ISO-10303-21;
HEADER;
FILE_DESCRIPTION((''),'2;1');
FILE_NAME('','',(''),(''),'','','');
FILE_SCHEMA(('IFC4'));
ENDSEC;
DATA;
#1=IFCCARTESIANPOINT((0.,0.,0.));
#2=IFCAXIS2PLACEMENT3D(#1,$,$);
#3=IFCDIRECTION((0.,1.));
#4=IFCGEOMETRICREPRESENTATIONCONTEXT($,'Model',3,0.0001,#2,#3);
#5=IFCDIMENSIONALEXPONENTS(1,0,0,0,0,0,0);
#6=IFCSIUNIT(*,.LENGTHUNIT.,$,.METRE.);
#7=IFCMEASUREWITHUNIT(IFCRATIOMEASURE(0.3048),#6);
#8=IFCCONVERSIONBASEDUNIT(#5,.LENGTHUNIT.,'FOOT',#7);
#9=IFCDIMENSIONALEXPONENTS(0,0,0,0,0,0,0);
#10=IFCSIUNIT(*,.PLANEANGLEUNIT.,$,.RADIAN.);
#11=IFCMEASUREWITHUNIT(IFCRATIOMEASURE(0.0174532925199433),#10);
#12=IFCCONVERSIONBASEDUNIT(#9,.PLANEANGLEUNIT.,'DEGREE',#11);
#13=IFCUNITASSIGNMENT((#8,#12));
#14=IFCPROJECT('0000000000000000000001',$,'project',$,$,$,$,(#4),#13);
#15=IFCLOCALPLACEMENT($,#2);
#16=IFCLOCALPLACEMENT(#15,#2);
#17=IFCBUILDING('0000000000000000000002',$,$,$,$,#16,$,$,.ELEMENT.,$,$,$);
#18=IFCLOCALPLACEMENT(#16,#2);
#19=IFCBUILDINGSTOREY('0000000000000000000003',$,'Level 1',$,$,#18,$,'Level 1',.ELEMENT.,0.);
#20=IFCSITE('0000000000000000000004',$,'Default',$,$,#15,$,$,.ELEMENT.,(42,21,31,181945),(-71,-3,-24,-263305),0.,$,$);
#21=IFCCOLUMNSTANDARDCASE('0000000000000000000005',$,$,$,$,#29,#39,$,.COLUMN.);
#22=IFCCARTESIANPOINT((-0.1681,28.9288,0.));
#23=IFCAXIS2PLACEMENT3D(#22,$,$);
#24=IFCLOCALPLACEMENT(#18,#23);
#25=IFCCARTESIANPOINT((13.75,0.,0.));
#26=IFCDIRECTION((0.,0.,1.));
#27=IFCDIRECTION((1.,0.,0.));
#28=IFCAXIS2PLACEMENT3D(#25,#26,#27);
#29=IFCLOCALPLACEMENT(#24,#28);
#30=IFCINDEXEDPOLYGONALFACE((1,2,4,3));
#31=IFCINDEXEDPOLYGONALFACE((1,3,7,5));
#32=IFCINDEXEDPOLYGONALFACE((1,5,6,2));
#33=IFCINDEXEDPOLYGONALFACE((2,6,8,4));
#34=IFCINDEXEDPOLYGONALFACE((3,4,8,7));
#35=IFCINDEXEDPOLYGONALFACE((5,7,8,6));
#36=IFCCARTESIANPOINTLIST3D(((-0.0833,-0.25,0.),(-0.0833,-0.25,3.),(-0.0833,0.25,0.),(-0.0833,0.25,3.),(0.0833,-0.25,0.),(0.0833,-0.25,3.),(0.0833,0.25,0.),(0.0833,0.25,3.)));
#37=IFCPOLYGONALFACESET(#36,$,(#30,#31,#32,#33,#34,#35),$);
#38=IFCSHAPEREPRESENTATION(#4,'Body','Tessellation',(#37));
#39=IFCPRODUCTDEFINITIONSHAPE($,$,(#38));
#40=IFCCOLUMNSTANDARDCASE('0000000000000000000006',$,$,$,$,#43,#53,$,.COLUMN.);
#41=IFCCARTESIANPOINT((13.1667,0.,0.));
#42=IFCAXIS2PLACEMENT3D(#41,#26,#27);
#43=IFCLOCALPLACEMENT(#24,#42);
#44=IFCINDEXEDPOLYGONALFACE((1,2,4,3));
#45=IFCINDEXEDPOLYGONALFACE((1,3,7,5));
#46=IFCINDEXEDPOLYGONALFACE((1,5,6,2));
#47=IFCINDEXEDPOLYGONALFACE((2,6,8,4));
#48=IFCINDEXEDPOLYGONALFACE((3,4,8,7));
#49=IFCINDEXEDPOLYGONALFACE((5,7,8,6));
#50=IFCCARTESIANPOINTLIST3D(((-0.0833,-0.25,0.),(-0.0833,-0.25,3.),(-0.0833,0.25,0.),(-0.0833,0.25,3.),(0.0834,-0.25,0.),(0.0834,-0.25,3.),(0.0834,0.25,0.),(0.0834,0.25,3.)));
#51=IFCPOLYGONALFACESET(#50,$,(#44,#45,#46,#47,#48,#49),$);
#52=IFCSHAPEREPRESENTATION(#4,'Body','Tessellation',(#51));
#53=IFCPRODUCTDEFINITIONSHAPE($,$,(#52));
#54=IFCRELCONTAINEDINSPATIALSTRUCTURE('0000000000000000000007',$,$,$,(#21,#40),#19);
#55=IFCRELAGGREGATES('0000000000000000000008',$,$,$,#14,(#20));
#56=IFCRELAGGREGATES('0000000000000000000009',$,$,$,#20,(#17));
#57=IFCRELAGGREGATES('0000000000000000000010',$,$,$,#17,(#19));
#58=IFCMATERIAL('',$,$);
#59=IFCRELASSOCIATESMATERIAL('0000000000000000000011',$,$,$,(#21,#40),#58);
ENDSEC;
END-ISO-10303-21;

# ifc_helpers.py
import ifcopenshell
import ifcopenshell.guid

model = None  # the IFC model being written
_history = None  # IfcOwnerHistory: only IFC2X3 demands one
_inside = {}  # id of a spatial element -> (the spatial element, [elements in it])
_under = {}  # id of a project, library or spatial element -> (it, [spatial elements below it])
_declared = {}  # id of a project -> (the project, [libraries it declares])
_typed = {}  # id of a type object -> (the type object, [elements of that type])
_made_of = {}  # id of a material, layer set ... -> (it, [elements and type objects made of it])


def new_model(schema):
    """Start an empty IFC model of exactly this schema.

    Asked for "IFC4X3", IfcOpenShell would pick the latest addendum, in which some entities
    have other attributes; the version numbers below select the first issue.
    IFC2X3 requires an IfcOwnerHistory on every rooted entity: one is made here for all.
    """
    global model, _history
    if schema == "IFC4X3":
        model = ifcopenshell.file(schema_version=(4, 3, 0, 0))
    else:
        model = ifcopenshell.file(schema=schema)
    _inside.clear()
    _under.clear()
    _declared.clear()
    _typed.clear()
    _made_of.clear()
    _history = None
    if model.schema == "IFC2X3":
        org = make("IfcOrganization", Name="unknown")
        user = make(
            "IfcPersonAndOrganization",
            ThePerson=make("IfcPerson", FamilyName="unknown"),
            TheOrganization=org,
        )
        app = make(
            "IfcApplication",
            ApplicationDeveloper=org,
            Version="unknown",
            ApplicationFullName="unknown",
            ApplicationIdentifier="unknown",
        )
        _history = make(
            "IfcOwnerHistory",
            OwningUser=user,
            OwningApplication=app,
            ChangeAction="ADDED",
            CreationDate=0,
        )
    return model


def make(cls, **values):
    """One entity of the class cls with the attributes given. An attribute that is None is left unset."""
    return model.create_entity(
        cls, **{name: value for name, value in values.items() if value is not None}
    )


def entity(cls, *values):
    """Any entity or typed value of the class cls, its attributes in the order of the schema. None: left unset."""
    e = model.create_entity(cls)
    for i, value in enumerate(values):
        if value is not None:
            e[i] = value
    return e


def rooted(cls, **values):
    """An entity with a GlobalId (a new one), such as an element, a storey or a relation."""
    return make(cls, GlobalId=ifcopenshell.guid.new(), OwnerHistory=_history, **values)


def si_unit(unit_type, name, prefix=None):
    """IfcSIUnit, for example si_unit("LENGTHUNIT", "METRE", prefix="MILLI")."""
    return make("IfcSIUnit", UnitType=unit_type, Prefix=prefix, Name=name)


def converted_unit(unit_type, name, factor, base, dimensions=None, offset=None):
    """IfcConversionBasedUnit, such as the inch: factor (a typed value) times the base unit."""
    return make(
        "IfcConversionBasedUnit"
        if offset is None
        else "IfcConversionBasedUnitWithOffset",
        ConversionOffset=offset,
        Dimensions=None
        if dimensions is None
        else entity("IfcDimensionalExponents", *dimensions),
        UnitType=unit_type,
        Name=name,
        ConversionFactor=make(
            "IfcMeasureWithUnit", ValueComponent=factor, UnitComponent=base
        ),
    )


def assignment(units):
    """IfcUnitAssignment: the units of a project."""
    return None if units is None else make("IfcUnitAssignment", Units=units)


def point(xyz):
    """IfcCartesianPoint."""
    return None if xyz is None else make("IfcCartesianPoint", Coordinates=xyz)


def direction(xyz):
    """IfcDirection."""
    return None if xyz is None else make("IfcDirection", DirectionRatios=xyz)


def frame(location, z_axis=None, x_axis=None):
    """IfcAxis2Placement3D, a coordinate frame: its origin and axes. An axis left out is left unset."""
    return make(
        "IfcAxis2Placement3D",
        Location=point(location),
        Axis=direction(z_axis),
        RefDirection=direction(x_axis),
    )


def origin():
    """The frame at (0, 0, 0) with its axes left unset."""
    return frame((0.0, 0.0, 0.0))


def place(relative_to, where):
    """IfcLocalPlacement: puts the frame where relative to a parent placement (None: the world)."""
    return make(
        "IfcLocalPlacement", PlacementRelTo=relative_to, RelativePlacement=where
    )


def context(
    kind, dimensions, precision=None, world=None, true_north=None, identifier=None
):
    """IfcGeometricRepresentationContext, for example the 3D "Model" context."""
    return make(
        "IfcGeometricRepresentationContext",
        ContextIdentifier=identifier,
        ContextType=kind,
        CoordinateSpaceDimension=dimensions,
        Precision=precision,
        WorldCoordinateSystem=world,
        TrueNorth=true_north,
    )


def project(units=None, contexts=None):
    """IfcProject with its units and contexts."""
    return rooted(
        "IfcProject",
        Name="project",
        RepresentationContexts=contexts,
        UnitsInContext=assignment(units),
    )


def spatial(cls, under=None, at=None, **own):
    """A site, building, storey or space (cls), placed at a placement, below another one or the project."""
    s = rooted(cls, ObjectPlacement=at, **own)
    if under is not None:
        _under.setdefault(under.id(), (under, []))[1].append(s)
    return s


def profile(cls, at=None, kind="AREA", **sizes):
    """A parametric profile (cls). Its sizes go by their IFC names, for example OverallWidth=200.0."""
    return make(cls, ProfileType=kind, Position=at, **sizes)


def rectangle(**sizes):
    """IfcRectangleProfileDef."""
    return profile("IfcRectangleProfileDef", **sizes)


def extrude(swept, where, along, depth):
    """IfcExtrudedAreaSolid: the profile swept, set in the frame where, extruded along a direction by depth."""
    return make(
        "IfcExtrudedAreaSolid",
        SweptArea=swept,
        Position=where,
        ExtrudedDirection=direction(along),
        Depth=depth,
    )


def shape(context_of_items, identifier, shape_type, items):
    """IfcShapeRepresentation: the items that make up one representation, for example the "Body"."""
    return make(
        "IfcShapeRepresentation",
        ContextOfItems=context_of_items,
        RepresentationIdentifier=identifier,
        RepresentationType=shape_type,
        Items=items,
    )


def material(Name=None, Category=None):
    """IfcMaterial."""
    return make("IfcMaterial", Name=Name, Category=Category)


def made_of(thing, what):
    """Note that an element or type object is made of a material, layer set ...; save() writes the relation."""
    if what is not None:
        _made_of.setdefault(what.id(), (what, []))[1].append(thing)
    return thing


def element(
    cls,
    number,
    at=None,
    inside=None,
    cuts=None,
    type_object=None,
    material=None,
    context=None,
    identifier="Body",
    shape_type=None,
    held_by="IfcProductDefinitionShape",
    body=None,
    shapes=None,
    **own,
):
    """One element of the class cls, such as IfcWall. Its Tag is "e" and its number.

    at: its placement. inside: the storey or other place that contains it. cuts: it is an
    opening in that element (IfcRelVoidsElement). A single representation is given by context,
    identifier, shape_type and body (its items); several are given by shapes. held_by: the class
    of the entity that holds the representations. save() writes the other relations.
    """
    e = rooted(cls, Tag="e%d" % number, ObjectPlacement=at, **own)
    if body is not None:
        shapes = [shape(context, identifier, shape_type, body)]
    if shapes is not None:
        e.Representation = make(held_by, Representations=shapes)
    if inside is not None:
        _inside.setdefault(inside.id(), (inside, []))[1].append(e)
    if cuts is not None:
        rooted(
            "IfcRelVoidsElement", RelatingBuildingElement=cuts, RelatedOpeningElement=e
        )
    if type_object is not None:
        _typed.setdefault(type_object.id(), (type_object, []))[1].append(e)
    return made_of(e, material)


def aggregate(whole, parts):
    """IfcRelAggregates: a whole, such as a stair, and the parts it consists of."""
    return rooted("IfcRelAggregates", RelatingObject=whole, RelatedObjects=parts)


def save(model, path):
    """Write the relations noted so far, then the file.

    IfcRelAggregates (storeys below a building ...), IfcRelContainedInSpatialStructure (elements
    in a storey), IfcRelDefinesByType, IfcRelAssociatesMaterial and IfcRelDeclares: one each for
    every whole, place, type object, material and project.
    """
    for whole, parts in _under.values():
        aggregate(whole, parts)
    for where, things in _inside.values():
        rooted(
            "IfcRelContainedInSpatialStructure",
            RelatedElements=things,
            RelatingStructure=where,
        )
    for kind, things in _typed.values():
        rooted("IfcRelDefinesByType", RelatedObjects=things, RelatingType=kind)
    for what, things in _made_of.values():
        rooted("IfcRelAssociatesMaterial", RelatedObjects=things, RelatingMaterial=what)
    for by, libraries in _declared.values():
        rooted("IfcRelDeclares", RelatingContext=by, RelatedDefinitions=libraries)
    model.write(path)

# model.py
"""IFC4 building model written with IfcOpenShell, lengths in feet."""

from ifc_helpers import new_model, entity, si_unit, converted_unit, direction, frame, origin, place, context, project, spatial, rectangle, extrude, material, element, save


model = new_model("IFC4")

# Units and contexts
model_context = context("Model", 3, precision=0.0001, world=origin(), true_north=direction((0.0, 1.0)))
ifc_project = project(units=[converted_unit("LENGTHUNIT", "FOOT", entity("IfcRatioMeasure", 0.3048), si_unit("LENGTHUNIT", "METRE"), dimensions=[1, 0, 0, 0, 0, 0, 0]), converted_unit("PLANEANGLEUNIT", "DEGREE", entity("IfcRatioMeasure", 0.0174532925199433), si_unit("PLANEANGLEUNIT", "RADIAN"), dimensions=[0, 0, 0, 0, 0, 0, 0])], contexts=[model_context])

# Site, building, storey
site_placement = place(None, origin())
site = spatial("IfcSite", under=ifc_project, at=site_placement, Name="Default", CompositionType="ELEMENT", RefLatitude=(42, 21, 31, 181945), RefLongitude=(-71, -3, -24, -263305), RefElevation=0.0)
building_placement = place(site_placement, origin())
building = spatial("IfcBuilding", under=site, at=building_placement, CompositionType="ELEMENT")
storey_placement = place(building_placement, origin())
storey = spatial("IfcBuildingStorey", under=building, at=storey_placement, Name="Level 1", LongName="Level 1", CompositionType="ELEMENT", Elevation=0.0)

# Columns
ifc_material_1 = material(Name="")
placement = place(storey_placement, frame((-0.1681, 28.9288, 0.0)))
for number, where, z_axis, x_axis in (
    (1, (13.75, 0.0, 0.0), (0.0, 0.0, 1.0), (1.0, 0.0, 0.0)),
    (2, (13.1667, 0.0, 0.0), (0.0, 0.0, 1.0), (1.0, 0.0, 0.0)),
):
    element("IfcColumnStandardCase", number, at=place(placement, frame(where, z_axis=z_axis, x_axis=x_axis)), inside=storey, material=ifc_material_1, PredefinedType="COLUMN", context=model_context, shape_type="SweptSolid", body=[
        extrude(rectangle(XDim=0.1667, YDim=0.5), origin(), (0.0, 0.0, 1.0), 3.0),
    ])

save(model, "model.ifc")
